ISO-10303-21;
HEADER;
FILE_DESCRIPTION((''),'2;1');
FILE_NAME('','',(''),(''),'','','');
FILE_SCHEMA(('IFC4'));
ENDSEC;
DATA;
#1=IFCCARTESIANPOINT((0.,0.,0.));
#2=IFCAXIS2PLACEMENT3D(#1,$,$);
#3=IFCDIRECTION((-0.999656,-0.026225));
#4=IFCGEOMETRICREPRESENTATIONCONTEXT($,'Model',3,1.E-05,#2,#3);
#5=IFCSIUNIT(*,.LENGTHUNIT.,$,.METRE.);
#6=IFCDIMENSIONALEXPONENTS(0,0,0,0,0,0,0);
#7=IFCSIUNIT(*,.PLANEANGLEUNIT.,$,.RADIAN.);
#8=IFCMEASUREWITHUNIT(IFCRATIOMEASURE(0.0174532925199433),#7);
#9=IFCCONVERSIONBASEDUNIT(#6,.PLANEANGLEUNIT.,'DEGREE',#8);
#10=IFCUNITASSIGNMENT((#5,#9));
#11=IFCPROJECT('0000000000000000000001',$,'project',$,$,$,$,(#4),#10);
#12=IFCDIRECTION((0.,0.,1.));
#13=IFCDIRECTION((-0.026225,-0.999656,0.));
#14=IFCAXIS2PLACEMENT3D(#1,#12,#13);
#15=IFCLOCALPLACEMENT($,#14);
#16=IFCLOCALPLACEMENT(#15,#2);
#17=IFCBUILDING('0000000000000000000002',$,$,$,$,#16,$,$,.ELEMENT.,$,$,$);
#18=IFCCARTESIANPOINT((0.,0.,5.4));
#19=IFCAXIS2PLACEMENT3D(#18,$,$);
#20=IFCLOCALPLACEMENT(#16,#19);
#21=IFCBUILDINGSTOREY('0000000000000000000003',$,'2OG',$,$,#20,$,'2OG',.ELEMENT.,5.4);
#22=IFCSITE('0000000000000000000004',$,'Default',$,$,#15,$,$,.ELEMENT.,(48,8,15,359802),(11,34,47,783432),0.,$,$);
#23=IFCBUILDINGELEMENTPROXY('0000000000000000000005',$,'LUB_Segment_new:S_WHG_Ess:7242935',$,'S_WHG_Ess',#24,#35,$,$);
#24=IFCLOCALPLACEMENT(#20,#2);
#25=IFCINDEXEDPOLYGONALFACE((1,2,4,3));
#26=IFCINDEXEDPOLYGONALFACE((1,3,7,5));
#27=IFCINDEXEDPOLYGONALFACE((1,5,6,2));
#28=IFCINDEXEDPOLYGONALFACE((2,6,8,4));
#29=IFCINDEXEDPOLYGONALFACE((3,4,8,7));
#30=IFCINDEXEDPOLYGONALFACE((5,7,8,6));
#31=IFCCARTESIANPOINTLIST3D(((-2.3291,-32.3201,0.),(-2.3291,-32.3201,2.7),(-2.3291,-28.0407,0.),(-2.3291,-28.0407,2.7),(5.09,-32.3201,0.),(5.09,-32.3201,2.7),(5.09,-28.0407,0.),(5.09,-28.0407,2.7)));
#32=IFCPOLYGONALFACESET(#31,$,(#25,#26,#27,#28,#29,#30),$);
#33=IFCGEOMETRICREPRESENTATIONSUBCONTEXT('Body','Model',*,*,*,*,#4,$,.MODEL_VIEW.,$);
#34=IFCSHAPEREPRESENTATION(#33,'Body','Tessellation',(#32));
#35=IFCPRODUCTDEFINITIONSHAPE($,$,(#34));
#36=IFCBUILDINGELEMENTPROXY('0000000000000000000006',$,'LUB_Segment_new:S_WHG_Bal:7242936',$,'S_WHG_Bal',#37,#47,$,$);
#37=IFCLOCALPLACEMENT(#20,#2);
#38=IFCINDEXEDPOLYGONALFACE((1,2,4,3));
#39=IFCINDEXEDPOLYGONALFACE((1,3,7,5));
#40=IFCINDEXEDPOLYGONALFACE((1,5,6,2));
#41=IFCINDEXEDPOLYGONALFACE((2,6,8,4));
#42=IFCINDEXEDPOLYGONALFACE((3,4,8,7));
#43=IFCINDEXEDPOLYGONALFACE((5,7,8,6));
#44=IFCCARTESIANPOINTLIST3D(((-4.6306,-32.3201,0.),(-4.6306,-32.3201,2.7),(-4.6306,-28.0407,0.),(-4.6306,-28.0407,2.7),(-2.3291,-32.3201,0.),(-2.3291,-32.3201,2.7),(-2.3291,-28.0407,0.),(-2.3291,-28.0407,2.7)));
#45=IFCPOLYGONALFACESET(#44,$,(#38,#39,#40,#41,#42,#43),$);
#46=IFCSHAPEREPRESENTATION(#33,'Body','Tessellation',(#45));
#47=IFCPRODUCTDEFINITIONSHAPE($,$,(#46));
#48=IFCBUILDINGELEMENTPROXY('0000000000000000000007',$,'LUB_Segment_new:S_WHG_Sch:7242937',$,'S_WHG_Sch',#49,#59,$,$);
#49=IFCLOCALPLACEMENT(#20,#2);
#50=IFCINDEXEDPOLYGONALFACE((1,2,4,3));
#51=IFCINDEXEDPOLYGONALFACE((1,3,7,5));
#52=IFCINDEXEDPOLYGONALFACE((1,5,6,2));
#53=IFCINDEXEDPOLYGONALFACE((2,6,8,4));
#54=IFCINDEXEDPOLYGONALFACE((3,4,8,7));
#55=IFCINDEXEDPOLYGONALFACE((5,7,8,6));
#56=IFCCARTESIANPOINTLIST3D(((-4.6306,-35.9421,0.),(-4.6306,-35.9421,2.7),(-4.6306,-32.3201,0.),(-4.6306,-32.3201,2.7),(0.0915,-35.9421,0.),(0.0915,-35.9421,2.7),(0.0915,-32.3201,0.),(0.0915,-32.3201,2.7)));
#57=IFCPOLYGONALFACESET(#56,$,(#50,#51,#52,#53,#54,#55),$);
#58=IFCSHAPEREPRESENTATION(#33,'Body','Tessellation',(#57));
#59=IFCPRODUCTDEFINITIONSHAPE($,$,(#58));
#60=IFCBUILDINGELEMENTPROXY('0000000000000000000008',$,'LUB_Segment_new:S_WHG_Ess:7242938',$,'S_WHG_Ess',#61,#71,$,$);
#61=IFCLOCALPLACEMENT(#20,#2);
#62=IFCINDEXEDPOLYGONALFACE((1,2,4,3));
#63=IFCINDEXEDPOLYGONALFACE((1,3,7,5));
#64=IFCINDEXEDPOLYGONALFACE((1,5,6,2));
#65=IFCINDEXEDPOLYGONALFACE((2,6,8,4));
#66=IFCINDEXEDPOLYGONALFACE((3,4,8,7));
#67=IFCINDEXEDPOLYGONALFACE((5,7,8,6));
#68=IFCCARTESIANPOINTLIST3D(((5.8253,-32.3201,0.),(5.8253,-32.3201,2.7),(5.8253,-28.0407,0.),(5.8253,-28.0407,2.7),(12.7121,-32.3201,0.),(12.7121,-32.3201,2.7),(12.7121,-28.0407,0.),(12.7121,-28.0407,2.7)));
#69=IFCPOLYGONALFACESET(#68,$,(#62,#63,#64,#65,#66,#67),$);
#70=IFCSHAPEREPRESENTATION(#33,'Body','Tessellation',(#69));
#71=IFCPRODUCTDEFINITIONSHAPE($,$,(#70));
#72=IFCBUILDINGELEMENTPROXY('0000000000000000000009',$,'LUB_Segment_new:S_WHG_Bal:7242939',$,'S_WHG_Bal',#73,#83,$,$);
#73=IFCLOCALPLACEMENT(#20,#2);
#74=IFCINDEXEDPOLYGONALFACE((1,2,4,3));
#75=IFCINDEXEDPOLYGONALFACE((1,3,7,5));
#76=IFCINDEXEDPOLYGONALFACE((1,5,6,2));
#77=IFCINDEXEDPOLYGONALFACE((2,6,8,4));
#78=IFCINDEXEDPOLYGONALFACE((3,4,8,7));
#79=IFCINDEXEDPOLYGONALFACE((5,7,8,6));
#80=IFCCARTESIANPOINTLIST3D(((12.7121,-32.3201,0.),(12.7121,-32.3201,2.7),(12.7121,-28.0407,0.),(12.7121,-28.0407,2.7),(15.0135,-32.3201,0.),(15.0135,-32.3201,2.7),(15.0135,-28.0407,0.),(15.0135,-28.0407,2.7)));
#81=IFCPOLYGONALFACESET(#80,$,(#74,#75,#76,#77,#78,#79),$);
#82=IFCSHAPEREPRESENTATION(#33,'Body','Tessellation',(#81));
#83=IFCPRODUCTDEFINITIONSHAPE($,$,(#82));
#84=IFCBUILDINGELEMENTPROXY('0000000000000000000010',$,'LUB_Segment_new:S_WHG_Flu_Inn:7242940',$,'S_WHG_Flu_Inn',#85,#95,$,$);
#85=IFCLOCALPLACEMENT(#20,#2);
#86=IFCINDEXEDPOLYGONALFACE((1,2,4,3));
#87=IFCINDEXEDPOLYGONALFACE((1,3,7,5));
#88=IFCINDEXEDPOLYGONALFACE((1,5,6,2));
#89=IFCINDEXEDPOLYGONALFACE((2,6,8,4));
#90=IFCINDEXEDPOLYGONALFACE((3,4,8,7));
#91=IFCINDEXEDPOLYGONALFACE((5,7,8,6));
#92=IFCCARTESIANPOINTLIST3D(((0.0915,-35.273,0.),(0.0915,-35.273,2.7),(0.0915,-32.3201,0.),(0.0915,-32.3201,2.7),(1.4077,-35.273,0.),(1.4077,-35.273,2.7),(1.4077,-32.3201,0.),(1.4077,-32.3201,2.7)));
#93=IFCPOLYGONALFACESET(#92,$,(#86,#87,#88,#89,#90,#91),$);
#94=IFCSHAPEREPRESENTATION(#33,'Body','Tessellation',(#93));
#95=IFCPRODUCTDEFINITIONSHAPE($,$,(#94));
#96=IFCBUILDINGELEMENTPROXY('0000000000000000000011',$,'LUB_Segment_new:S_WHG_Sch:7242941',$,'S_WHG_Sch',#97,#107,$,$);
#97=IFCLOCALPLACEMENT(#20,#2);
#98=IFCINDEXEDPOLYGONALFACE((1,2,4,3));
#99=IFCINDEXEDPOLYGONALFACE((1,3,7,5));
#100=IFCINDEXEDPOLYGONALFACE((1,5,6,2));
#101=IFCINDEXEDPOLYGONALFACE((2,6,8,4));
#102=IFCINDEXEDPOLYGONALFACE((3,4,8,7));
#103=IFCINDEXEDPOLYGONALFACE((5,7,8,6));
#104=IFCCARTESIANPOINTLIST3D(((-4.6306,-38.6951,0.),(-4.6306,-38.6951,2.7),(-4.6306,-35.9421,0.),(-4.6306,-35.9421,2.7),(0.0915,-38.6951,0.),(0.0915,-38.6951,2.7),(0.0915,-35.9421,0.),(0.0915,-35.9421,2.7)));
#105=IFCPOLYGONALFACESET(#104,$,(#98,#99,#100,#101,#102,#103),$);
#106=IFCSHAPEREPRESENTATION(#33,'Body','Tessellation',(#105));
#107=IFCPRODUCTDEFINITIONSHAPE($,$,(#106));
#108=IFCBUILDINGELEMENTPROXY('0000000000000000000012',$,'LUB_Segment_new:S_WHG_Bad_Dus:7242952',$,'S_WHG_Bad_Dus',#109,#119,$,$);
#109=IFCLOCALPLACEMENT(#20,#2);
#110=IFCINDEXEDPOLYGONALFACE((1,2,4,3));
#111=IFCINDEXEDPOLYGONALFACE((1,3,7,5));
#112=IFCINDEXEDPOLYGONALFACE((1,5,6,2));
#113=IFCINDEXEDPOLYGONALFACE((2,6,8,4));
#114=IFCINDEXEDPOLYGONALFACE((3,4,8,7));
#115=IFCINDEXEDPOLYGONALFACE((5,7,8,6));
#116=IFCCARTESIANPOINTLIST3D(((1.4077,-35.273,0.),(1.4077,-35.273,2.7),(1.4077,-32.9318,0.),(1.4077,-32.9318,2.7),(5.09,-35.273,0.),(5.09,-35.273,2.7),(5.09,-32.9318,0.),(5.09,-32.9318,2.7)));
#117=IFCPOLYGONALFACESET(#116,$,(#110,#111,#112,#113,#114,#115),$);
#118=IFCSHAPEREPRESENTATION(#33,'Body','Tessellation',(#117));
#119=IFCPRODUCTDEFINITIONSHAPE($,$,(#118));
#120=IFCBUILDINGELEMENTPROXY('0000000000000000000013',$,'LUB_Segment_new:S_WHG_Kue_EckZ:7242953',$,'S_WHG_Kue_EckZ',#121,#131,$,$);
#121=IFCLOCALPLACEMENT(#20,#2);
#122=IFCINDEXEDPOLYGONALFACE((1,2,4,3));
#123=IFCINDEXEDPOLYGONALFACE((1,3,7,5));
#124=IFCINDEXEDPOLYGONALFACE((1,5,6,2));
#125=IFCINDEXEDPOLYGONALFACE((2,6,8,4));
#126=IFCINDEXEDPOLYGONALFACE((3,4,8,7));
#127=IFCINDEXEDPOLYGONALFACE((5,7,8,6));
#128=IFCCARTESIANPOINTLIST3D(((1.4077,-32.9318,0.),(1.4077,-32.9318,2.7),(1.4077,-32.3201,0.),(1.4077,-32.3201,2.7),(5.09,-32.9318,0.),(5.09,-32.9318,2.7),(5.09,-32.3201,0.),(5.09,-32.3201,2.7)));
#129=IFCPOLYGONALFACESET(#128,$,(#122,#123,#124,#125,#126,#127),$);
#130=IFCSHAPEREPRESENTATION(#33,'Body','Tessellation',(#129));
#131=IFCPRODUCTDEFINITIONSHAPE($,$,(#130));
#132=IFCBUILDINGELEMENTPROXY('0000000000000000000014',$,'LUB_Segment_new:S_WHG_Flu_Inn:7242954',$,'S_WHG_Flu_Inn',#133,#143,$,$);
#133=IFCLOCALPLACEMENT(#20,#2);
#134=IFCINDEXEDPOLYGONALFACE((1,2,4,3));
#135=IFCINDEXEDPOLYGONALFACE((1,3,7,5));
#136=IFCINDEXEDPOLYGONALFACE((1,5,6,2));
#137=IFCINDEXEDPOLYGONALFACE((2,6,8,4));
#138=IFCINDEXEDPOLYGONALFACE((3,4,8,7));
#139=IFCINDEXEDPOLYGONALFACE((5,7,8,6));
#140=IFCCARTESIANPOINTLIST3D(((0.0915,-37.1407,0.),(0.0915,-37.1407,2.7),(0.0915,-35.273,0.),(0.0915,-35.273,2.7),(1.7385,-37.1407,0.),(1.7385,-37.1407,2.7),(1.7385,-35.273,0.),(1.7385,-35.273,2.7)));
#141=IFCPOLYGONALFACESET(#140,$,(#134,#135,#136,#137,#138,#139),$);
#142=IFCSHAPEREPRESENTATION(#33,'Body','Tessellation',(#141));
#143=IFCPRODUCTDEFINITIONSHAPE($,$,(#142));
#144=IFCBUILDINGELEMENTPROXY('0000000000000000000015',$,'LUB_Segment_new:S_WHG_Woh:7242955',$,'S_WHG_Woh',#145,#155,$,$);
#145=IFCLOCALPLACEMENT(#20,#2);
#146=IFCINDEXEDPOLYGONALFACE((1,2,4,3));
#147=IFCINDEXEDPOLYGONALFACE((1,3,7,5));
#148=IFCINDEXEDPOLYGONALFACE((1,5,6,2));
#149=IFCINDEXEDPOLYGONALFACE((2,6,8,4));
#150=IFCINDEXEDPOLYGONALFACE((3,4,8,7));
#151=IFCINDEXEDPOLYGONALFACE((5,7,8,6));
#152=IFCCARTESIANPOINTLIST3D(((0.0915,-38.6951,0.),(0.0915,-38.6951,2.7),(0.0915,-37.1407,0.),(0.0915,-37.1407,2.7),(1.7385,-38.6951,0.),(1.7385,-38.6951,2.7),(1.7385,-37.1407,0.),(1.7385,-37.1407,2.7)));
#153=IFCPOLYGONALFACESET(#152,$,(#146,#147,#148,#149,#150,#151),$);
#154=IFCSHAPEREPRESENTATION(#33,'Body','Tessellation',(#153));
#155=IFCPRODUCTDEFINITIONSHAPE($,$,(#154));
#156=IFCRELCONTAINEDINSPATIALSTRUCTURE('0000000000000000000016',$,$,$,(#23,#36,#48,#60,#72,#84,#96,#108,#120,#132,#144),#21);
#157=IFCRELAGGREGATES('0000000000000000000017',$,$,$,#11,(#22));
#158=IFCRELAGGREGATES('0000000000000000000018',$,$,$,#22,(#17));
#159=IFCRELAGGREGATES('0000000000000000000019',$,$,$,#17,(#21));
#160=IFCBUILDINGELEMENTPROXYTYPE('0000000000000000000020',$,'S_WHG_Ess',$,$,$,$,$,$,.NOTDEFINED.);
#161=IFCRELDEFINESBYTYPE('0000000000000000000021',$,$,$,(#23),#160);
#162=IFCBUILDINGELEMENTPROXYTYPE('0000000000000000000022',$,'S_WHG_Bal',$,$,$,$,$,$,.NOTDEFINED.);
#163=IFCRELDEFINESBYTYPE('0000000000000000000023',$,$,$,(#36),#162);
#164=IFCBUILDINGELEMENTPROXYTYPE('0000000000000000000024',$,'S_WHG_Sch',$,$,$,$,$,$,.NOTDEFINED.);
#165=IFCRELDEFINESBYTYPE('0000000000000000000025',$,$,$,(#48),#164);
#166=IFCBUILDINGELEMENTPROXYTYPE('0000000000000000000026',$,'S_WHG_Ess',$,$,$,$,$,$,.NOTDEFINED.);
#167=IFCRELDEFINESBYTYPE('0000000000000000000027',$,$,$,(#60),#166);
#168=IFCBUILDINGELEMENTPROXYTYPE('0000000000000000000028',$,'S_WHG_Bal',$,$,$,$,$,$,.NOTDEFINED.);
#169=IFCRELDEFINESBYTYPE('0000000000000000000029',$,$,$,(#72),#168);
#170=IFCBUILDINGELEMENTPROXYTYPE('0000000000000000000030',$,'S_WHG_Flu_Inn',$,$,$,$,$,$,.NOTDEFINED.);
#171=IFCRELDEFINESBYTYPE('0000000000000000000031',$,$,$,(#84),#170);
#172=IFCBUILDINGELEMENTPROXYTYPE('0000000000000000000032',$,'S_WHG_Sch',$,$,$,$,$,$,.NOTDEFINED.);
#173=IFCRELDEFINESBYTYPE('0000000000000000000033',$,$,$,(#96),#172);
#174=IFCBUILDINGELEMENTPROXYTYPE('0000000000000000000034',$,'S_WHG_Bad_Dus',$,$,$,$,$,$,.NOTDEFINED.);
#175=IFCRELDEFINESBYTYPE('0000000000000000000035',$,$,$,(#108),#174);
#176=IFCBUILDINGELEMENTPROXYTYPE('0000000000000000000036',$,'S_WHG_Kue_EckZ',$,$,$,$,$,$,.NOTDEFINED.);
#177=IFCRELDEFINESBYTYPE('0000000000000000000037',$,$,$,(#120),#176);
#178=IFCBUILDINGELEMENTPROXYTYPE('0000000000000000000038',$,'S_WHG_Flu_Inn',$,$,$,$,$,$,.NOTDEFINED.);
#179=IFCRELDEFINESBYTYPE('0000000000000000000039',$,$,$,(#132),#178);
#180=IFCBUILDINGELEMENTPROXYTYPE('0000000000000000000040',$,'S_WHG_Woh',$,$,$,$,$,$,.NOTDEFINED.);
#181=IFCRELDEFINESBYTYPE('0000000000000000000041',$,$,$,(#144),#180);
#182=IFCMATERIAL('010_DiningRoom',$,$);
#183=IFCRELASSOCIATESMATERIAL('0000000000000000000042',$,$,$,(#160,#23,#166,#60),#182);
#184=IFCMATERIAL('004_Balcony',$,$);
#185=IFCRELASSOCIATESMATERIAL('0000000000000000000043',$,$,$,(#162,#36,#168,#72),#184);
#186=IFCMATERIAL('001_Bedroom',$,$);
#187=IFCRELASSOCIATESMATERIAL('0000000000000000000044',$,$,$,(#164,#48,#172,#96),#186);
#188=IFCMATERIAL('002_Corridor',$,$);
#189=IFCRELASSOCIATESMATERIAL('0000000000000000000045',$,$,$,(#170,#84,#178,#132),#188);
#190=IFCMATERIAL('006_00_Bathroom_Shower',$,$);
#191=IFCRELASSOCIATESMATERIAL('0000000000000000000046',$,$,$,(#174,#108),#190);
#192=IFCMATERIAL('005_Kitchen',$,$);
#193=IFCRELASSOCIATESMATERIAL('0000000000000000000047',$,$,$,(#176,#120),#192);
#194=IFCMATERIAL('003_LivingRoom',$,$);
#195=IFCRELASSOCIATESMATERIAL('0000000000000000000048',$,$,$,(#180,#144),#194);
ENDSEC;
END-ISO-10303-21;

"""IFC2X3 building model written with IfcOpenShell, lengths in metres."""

from ifc_helpers import new_model, entity, si_unit, converted_unit, direction, frame, origin, origin_2d_with_axis, place, context, subcontext, project, spatial, rectangle, extrude, source, transform, mapped, material, type_object, type_shapes, element, save


model = new_model("IFC2X3")

# Units and contexts
model_context = context("Model", 3, precision=1e-05, world=origin(), true_north=direction((-0.999656, -0.026225)))
body_context = subcontext(model_context, "Body", "Model", "MODEL_VIEW")
ifc_project = project(units=[si_unit("LENGTHUNIT", "METRE"), converted_unit("PLANEANGLEUNIT", "DEGREE", entity("IfcRatioMeasure", 0.0174532925199433), si_unit("PLANEANGLEUNIT", "RADIAN"), dimensions=[0, 0, 0, 0, 0, 0, 0])], contexts=[model_context])

# Site, building, storey
site_placement = place(None, frame((0.0, 0.0, 0.0), z_axis=(0.0, 0.0, 1.0), x_axis=(-0.026225, -0.999656, 0.0)))
site = spatial("IfcSite", under=ifc_project, at=site_placement, Name="Default", CompositionType="ELEMENT", RefLatitude=(48, 8, 15, 359802), RefLongitude=(11, 34, 47, 783432), RefElevation=0.0)
building_placement = place(site_placement, origin())
building = spatial("IfcBuilding", under=site, at=building_placement, CompositionType="ELEMENT")
storey_placement = place(building_placement, frame((0.0, 0.0, 5.4)))
storey = spatial("IfcBuildingStorey", under=building, at=storey_placement, Name="2OG", LongName="2OG", CompositionType="ELEMENT", Elevation=5.4)

# Building element proxies
ifc_material_1 = material(Name="010_DiningRoom")
building_element_proxy_type_1 = type_object("IfcBuildingElementProxyType", Name="S_WHG_Ess", PredefinedType="NOTDEFINED", material=ifc_material_1)
shared_shape_1 = source(origin(), body_context, "Body", "SweptSolid", [
    extrude(rectangle(XDim=7.4191, YDim=4.2794, at=origin_2d_with_axis()), frame((0.0, 0.0, 0.0), z_axis=(0.0, 0.0, 1.0), x_axis=(-1.0, 0.0, 0.0)), (0.0, 0.0, 1.0), 2.7),
])
type_shapes(building_element_proxy_type_1, [shared_shape_1])
proxy_1_placement = place(storey_placement, frame((1.3805, -30.1804, 0.0)))
element("IfcBuildingElementProxy", 1, at=proxy_1_placement, inside=storey, type_object=building_element_proxy_type_1, material=ifc_material_1, Name="LUB_Segment_new:S_WHG_Ess:7242935", ObjectType="S_WHG_Ess", context=body_context, shape_type="MappedRepresentation", body=[
    mapped(shared_shape_1, transform((0.0, 0.0, 0.0), scale=1.0)),
])
ifc_material_2 = material(Name="004_Balcony")
building_element_proxy_type_2 = type_object("IfcBuildingElementProxyType", Name="S_WHG_Bal", PredefinedType="NOTDEFINED", material=ifc_material_2)
shared_shape_2 = source(origin(), body_context, "Body", "SweptSolid", [
    extrude(rectangle(XDim=2.3015, YDim=4.2794, at=origin_2d_with_axis()), frame((0.0, 0.0, 0.0), z_axis=(0.0, 0.0, 1.0), x_axis=(-1.0, 0.0, 0.0)), (0.0, 0.0, 1.0), 2.7),
])
type_shapes(building_element_proxy_type_2, [shared_shape_2])
proxy_2_placement = place(storey_placement, frame((-3.4798, -30.1804, 0.0)))
element("IfcBuildingElementProxy", 2, at=proxy_2_placement, inside=storey, type_object=building_element_proxy_type_2, material=ifc_material_2, Name="LUB_Segment_new:S_WHG_Bal:7242936", ObjectType="S_WHG_Bal", context=body_context, shape_type="MappedRepresentation", body=[
    mapped(shared_shape_2, transform((0.0, 0.0, 0.0), scale=1.0)),
])
ifc_material_3 = material(Name="001_Bedroom")
building_element_proxy_type_3 = type_object("IfcBuildingElementProxyType", Name="S_WHG_Sch", PredefinedType="NOTDEFINED", material=ifc_material_3)
shared_shape_3 = source(origin(), body_context, "Body", "SweptSolid", [
    extrude(rectangle(XDim=4.7221, YDim=3.6221, at=origin_2d_with_axis()), frame((0.0, 0.0, 0.0), z_axis=(0.0, 0.0, 1.0), x_axis=(-1.0, 0.0, 0.0)), (0.0, 0.0, 1.0), 2.7),
])
type_shapes(building_element_proxy_type_3, [shared_shape_3])
proxy_3_placement = place(storey_placement, frame((-2.2695, -34.1311, 0.0)))
element("IfcBuildingElementProxy", 3, at=proxy_3_placement, inside=storey, type_object=building_element_proxy_type_3, material=ifc_material_3, Name="LUB_Segment_new:S_WHG_Sch:7242937", ObjectType="S_WHG_Sch", context=body_context, shape_type="MappedRepresentation", body=[
    mapped(shared_shape_3, transform((0.0, 0.0, 0.0), scale=1.0)),
])
building_element_proxy_type_4 = type_object("IfcBuildingElementProxyType", Name="S_WHG_Ess", PredefinedType="NOTDEFINED", material=ifc_material_1)
shared_shape_4 = source(origin(), body_context, "Body", "SweptSolid", [
    extrude(rectangle(XDim=6.8868, YDim=4.2794, at=origin_2d_with_axis()), frame((0.0, 0.0, 0.0), z_axis=(0.0, 0.0, 1.0), x_axis=(-1.0, 0.0, 0.0)), (0.0, 0.0, 1.0), 2.7),
])
type_shapes(building_element_proxy_type_4, [shared_shape_4])
proxy_4_placement = place(storey_placement, frame((9.2687, -30.1804, 0.0)))
element("IfcBuildingElementProxy", 4, at=proxy_4_placement, inside=storey, type_object=building_element_proxy_type_4, material=ifc_material_1, Name="LUB_Segment_new:S_WHG_Ess:7242938", ObjectType="S_WHG_Ess", context=body_context, shape_type="MappedRepresentation", body=[
    mapped(shared_shape_4, transform((0.0, 0.0, 0.0), scale=1.0)),
])
building_element_proxy_type_5 = type_object("IfcBuildingElementProxyType", Name="S_WHG_Bal", PredefinedType="NOTDEFINED", material=ifc_material_2)
shared_shape_5 = source(origin(), body_context, "Body", "SweptSolid", [
    extrude(rectangle(XDim=4.2794, YDim=2.3015, at=origin_2d_with_axis()), frame((0.0, 0.0, 0.0), z_axis=(0.0, 0.0, 1.0), x_axis=(0.0, 1.0, 0.0)), (0.0, 0.0, 1.0), 2.7),
])
type_shapes(building_element_proxy_type_5, [shared_shape_5])
proxy_5_placement = place(storey_placement, frame((13.8628, -30.1804, 0.0), z_axis=(0.0, 0.0, 1.0), x_axis=(-1.0, 0.0, 0.0)))
element("IfcBuildingElementProxy", 5, at=proxy_5_placement, inside=storey, type_object=building_element_proxy_type_5, material=ifc_material_2, Name="LUB_Segment_new:S_WHG_Bal:7242939", ObjectType="S_WHG_Bal", context=body_context, shape_type="MappedRepresentation", body=[
    mapped(shared_shape_5, transform((0.0, 0.0, 0.0), scale=1.0)),
])
ifc_material_4 = material(Name="002_Corridor")
building_element_proxy_type_6 = type_object("IfcBuildingElementProxyType", Name="S_WHG_Flu_Inn", PredefinedType="NOTDEFINED", material=ifc_material_4)
shared_shape_6 = source(origin(), body_context, "Body", "SweptSolid", [
    extrude(rectangle(XDim=1.3162, YDim=2.9529, at=origin_2d_with_axis()), frame((0.0, 0.0, 0.0), z_axis=(0.0, 0.0, 1.0), x_axis=(-1.0, 0.0, 0.0)), (0.0, 0.0, 1.0), 2.7),
])
type_shapes(building_element_proxy_type_6, [shared_shape_6])
proxy_6_placement = place(storey_placement, frame((0.7496, -33.7966, 0.0)))
element("IfcBuildingElementProxy", 6, at=proxy_6_placement, inside=storey, type_object=building_element_proxy_type_6, material=ifc_material_4, Name="LUB_Segment_new:S_WHG_Flu_Inn:7242940", ObjectType="S_WHG_Flu_Inn", context=body_context, shape_type="MappedRepresentation", body=[
    mapped(shared_shape_6, transform((0.0, 0.0, 0.0), scale=1.0)),
])
building_element_proxy_type_7 = type_object("IfcBuildingElementProxyType", Name="S_WHG_Sch", PredefinedType="NOTDEFINED", material=ifc_material_3)
shared_shape_7 = source(origin(), body_context, "Body", "SweptSolid", [
    extrude(rectangle(XDim=4.7221, YDim=2.7529, at=origin_2d_with_axis()), frame((0.0, 0.0, 0.0), z_axis=(0.0, 0.0, 1.0), x_axis=(-1.0, 0.0, 0.0)), (0.0, 0.0, 1.0), 2.7),
])
type_shapes(building_element_proxy_type_7, [shared_shape_7])
proxy_7_placement = place(storey_placement, frame((-2.2695, -37.3186, 0.0)))
element("IfcBuildingElementProxy", 7, at=proxy_7_placement, inside=storey, type_object=building_element_proxy_type_7, material=ifc_material_3, Name="LUB_Segment_new:S_WHG_Sch:7242941", ObjectType="S_WHG_Sch", context=body_context, shape_type="MappedRepresentation", body=[
    mapped(shared_shape_7, transform((0.0, 0.0, 0.0), scale=1.0)),
])
ifc_material_5 = material(Name="006_00_Bathroom_Shower")
building_element_proxy_type_8 = type_object("IfcBuildingElementProxyType", Name="S_WHG_Bad_Dus", PredefinedType="NOTDEFINED", material=ifc_material_5)
shared_shape_8 = source(origin(), body_context, "Body", "SweptSolid", [
    extrude(rectangle(XDim=2.3412, YDim=3.6824, at=origin_2d_with_axis()), frame((0.0, 0.0, 0.0), z_axis=(0.0, 0.0, 1.0), x_axis=(0.0, 1.0, 0.0)), (0.0, 0.0, 1.0), 2.7),
])
type_shapes(building_element_proxy_type_8, [shared_shape_8])
proxy_8_placement = place(storey_placement, frame((3.2488, -34.1024, 0.0)))
element("IfcBuildingElementProxy", 8, at=proxy_8_placement, inside=storey, type_object=building_element_proxy_type_8, material=ifc_material_5, Name="LUB_Segment_new:S_WHG_Bad_Dus:7242952", ObjectType="S_WHG_Bad_Dus", context=body_context, shape_type="MappedRepresentation", body=[
    mapped(shared_shape_8, transform((0.0, 0.0, 0.0), scale=1.0)),
])
ifc_material_6 = material(Name="005_Kitchen")
building_element_proxy_type_9 = type_object("IfcBuildingElementProxyType", Name="S_WHG_Kue_EckZ", PredefinedType="NOTDEFINED", material=ifc_material_6)
shared_shape_9 = source(origin(), body_context, "Body", "SweptSolid", [
    extrude(rectangle(XDim=0.6118, YDim=3.6824, at=origin_2d_with_axis()), frame((0.0, 0.0, 0.0), z_axis=(0.0, 0.0, 1.0), x_axis=(0.0, 1.0, 0.0)), (0.0, 0.0, 1.0), 2.7),
])
type_shapes(building_element_proxy_type_9, [shared_shape_9])
proxy_9_placement = place(storey_placement, frame((3.2488, -32.626, 0.0)))
element("IfcBuildingElementProxy", 9, at=proxy_9_placement, inside=storey, type_object=building_element_proxy_type_9, material=ifc_material_6, Name="LUB_Segment_new:S_WHG_Kue_EckZ:7242953", ObjectType="S_WHG_Kue_EckZ", context=body_context, shape_type="MappedRepresentation", body=[
    mapped(shared_shape_9, transform((0.0, 0.0, 0.0), scale=1.0)),
])
building_element_proxy_type_10 = type_object("IfcBuildingElementProxyType", Name="S_WHG_Flu_Inn", PredefinedType="NOTDEFINED", material=ifc_material_4)
shared_shape_10 = source(origin(), body_context, "Body", "SweptSolid", [
    extrude(rectangle(XDim=1.6471, YDim=1.8676, at=origin_2d_with_axis()), frame((0.0, 0.0, 0.0), z_axis=(0.0, 0.0, 1.0), x_axis=(-1.0, 0.0, 0.0)), (0.0, 0.0, 1.0), 2.7),
])
type_shapes(building_element_proxy_type_10, [shared_shape_10])
proxy_10_placement = place(storey_placement, frame((0.915, -36.2068, 0.0)))
element("IfcBuildingElementProxy", 10, at=proxy_10_placement, inside=storey, type_object=building_element_proxy_type_10, material=ifc_material_4, Name="LUB_Segment_new:S_WHG_Flu_Inn:7242954", ObjectType="S_WHG_Flu_Inn", context=body_context, shape_type="MappedRepresentation", body=[
    mapped(shared_shape_10, transform((0.0, 0.0, 0.0), scale=1.0)),
])
ifc_material_7 = material(Name="003_LivingRoom")
building_element_proxy_type_11 = type_object("IfcBuildingElementProxyType", Name="S_WHG_Woh", PredefinedType="NOTDEFINED", material=ifc_material_7)
shared_shape_11 = source(origin(), body_context, "Body", "SweptSolid", [
    extrude(rectangle(XDim=1.6471, YDim=1.5544, at=origin_2d_with_axis()), frame((0.0, 0.0, 0.0), z_axis=(0.0, 0.0, 1.0), x_axis=(-1.0, 0.0, 0.0)), (0.0, 0.0, 1.0), 2.7),
])
type_shapes(building_element_proxy_type_11, [shared_shape_11])
proxy_11_placement = place(storey_placement, frame((0.915, -37.9179, 0.0)))
element("IfcBuildingElementProxy", 11, at=proxy_11_placement, inside=storey, type_object=building_element_proxy_type_11, material=ifc_material_7, Name="LUB_Segment_new:S_WHG_Woh:7242955", ObjectType="S_WHG_Woh", context=body_context, shape_type="MappedRepresentation", body=[
    mapped(shared_shape_11, transform((0.0, 0.0, 0.0), scale=1.0)),
])

save(model, "model.ifc")
